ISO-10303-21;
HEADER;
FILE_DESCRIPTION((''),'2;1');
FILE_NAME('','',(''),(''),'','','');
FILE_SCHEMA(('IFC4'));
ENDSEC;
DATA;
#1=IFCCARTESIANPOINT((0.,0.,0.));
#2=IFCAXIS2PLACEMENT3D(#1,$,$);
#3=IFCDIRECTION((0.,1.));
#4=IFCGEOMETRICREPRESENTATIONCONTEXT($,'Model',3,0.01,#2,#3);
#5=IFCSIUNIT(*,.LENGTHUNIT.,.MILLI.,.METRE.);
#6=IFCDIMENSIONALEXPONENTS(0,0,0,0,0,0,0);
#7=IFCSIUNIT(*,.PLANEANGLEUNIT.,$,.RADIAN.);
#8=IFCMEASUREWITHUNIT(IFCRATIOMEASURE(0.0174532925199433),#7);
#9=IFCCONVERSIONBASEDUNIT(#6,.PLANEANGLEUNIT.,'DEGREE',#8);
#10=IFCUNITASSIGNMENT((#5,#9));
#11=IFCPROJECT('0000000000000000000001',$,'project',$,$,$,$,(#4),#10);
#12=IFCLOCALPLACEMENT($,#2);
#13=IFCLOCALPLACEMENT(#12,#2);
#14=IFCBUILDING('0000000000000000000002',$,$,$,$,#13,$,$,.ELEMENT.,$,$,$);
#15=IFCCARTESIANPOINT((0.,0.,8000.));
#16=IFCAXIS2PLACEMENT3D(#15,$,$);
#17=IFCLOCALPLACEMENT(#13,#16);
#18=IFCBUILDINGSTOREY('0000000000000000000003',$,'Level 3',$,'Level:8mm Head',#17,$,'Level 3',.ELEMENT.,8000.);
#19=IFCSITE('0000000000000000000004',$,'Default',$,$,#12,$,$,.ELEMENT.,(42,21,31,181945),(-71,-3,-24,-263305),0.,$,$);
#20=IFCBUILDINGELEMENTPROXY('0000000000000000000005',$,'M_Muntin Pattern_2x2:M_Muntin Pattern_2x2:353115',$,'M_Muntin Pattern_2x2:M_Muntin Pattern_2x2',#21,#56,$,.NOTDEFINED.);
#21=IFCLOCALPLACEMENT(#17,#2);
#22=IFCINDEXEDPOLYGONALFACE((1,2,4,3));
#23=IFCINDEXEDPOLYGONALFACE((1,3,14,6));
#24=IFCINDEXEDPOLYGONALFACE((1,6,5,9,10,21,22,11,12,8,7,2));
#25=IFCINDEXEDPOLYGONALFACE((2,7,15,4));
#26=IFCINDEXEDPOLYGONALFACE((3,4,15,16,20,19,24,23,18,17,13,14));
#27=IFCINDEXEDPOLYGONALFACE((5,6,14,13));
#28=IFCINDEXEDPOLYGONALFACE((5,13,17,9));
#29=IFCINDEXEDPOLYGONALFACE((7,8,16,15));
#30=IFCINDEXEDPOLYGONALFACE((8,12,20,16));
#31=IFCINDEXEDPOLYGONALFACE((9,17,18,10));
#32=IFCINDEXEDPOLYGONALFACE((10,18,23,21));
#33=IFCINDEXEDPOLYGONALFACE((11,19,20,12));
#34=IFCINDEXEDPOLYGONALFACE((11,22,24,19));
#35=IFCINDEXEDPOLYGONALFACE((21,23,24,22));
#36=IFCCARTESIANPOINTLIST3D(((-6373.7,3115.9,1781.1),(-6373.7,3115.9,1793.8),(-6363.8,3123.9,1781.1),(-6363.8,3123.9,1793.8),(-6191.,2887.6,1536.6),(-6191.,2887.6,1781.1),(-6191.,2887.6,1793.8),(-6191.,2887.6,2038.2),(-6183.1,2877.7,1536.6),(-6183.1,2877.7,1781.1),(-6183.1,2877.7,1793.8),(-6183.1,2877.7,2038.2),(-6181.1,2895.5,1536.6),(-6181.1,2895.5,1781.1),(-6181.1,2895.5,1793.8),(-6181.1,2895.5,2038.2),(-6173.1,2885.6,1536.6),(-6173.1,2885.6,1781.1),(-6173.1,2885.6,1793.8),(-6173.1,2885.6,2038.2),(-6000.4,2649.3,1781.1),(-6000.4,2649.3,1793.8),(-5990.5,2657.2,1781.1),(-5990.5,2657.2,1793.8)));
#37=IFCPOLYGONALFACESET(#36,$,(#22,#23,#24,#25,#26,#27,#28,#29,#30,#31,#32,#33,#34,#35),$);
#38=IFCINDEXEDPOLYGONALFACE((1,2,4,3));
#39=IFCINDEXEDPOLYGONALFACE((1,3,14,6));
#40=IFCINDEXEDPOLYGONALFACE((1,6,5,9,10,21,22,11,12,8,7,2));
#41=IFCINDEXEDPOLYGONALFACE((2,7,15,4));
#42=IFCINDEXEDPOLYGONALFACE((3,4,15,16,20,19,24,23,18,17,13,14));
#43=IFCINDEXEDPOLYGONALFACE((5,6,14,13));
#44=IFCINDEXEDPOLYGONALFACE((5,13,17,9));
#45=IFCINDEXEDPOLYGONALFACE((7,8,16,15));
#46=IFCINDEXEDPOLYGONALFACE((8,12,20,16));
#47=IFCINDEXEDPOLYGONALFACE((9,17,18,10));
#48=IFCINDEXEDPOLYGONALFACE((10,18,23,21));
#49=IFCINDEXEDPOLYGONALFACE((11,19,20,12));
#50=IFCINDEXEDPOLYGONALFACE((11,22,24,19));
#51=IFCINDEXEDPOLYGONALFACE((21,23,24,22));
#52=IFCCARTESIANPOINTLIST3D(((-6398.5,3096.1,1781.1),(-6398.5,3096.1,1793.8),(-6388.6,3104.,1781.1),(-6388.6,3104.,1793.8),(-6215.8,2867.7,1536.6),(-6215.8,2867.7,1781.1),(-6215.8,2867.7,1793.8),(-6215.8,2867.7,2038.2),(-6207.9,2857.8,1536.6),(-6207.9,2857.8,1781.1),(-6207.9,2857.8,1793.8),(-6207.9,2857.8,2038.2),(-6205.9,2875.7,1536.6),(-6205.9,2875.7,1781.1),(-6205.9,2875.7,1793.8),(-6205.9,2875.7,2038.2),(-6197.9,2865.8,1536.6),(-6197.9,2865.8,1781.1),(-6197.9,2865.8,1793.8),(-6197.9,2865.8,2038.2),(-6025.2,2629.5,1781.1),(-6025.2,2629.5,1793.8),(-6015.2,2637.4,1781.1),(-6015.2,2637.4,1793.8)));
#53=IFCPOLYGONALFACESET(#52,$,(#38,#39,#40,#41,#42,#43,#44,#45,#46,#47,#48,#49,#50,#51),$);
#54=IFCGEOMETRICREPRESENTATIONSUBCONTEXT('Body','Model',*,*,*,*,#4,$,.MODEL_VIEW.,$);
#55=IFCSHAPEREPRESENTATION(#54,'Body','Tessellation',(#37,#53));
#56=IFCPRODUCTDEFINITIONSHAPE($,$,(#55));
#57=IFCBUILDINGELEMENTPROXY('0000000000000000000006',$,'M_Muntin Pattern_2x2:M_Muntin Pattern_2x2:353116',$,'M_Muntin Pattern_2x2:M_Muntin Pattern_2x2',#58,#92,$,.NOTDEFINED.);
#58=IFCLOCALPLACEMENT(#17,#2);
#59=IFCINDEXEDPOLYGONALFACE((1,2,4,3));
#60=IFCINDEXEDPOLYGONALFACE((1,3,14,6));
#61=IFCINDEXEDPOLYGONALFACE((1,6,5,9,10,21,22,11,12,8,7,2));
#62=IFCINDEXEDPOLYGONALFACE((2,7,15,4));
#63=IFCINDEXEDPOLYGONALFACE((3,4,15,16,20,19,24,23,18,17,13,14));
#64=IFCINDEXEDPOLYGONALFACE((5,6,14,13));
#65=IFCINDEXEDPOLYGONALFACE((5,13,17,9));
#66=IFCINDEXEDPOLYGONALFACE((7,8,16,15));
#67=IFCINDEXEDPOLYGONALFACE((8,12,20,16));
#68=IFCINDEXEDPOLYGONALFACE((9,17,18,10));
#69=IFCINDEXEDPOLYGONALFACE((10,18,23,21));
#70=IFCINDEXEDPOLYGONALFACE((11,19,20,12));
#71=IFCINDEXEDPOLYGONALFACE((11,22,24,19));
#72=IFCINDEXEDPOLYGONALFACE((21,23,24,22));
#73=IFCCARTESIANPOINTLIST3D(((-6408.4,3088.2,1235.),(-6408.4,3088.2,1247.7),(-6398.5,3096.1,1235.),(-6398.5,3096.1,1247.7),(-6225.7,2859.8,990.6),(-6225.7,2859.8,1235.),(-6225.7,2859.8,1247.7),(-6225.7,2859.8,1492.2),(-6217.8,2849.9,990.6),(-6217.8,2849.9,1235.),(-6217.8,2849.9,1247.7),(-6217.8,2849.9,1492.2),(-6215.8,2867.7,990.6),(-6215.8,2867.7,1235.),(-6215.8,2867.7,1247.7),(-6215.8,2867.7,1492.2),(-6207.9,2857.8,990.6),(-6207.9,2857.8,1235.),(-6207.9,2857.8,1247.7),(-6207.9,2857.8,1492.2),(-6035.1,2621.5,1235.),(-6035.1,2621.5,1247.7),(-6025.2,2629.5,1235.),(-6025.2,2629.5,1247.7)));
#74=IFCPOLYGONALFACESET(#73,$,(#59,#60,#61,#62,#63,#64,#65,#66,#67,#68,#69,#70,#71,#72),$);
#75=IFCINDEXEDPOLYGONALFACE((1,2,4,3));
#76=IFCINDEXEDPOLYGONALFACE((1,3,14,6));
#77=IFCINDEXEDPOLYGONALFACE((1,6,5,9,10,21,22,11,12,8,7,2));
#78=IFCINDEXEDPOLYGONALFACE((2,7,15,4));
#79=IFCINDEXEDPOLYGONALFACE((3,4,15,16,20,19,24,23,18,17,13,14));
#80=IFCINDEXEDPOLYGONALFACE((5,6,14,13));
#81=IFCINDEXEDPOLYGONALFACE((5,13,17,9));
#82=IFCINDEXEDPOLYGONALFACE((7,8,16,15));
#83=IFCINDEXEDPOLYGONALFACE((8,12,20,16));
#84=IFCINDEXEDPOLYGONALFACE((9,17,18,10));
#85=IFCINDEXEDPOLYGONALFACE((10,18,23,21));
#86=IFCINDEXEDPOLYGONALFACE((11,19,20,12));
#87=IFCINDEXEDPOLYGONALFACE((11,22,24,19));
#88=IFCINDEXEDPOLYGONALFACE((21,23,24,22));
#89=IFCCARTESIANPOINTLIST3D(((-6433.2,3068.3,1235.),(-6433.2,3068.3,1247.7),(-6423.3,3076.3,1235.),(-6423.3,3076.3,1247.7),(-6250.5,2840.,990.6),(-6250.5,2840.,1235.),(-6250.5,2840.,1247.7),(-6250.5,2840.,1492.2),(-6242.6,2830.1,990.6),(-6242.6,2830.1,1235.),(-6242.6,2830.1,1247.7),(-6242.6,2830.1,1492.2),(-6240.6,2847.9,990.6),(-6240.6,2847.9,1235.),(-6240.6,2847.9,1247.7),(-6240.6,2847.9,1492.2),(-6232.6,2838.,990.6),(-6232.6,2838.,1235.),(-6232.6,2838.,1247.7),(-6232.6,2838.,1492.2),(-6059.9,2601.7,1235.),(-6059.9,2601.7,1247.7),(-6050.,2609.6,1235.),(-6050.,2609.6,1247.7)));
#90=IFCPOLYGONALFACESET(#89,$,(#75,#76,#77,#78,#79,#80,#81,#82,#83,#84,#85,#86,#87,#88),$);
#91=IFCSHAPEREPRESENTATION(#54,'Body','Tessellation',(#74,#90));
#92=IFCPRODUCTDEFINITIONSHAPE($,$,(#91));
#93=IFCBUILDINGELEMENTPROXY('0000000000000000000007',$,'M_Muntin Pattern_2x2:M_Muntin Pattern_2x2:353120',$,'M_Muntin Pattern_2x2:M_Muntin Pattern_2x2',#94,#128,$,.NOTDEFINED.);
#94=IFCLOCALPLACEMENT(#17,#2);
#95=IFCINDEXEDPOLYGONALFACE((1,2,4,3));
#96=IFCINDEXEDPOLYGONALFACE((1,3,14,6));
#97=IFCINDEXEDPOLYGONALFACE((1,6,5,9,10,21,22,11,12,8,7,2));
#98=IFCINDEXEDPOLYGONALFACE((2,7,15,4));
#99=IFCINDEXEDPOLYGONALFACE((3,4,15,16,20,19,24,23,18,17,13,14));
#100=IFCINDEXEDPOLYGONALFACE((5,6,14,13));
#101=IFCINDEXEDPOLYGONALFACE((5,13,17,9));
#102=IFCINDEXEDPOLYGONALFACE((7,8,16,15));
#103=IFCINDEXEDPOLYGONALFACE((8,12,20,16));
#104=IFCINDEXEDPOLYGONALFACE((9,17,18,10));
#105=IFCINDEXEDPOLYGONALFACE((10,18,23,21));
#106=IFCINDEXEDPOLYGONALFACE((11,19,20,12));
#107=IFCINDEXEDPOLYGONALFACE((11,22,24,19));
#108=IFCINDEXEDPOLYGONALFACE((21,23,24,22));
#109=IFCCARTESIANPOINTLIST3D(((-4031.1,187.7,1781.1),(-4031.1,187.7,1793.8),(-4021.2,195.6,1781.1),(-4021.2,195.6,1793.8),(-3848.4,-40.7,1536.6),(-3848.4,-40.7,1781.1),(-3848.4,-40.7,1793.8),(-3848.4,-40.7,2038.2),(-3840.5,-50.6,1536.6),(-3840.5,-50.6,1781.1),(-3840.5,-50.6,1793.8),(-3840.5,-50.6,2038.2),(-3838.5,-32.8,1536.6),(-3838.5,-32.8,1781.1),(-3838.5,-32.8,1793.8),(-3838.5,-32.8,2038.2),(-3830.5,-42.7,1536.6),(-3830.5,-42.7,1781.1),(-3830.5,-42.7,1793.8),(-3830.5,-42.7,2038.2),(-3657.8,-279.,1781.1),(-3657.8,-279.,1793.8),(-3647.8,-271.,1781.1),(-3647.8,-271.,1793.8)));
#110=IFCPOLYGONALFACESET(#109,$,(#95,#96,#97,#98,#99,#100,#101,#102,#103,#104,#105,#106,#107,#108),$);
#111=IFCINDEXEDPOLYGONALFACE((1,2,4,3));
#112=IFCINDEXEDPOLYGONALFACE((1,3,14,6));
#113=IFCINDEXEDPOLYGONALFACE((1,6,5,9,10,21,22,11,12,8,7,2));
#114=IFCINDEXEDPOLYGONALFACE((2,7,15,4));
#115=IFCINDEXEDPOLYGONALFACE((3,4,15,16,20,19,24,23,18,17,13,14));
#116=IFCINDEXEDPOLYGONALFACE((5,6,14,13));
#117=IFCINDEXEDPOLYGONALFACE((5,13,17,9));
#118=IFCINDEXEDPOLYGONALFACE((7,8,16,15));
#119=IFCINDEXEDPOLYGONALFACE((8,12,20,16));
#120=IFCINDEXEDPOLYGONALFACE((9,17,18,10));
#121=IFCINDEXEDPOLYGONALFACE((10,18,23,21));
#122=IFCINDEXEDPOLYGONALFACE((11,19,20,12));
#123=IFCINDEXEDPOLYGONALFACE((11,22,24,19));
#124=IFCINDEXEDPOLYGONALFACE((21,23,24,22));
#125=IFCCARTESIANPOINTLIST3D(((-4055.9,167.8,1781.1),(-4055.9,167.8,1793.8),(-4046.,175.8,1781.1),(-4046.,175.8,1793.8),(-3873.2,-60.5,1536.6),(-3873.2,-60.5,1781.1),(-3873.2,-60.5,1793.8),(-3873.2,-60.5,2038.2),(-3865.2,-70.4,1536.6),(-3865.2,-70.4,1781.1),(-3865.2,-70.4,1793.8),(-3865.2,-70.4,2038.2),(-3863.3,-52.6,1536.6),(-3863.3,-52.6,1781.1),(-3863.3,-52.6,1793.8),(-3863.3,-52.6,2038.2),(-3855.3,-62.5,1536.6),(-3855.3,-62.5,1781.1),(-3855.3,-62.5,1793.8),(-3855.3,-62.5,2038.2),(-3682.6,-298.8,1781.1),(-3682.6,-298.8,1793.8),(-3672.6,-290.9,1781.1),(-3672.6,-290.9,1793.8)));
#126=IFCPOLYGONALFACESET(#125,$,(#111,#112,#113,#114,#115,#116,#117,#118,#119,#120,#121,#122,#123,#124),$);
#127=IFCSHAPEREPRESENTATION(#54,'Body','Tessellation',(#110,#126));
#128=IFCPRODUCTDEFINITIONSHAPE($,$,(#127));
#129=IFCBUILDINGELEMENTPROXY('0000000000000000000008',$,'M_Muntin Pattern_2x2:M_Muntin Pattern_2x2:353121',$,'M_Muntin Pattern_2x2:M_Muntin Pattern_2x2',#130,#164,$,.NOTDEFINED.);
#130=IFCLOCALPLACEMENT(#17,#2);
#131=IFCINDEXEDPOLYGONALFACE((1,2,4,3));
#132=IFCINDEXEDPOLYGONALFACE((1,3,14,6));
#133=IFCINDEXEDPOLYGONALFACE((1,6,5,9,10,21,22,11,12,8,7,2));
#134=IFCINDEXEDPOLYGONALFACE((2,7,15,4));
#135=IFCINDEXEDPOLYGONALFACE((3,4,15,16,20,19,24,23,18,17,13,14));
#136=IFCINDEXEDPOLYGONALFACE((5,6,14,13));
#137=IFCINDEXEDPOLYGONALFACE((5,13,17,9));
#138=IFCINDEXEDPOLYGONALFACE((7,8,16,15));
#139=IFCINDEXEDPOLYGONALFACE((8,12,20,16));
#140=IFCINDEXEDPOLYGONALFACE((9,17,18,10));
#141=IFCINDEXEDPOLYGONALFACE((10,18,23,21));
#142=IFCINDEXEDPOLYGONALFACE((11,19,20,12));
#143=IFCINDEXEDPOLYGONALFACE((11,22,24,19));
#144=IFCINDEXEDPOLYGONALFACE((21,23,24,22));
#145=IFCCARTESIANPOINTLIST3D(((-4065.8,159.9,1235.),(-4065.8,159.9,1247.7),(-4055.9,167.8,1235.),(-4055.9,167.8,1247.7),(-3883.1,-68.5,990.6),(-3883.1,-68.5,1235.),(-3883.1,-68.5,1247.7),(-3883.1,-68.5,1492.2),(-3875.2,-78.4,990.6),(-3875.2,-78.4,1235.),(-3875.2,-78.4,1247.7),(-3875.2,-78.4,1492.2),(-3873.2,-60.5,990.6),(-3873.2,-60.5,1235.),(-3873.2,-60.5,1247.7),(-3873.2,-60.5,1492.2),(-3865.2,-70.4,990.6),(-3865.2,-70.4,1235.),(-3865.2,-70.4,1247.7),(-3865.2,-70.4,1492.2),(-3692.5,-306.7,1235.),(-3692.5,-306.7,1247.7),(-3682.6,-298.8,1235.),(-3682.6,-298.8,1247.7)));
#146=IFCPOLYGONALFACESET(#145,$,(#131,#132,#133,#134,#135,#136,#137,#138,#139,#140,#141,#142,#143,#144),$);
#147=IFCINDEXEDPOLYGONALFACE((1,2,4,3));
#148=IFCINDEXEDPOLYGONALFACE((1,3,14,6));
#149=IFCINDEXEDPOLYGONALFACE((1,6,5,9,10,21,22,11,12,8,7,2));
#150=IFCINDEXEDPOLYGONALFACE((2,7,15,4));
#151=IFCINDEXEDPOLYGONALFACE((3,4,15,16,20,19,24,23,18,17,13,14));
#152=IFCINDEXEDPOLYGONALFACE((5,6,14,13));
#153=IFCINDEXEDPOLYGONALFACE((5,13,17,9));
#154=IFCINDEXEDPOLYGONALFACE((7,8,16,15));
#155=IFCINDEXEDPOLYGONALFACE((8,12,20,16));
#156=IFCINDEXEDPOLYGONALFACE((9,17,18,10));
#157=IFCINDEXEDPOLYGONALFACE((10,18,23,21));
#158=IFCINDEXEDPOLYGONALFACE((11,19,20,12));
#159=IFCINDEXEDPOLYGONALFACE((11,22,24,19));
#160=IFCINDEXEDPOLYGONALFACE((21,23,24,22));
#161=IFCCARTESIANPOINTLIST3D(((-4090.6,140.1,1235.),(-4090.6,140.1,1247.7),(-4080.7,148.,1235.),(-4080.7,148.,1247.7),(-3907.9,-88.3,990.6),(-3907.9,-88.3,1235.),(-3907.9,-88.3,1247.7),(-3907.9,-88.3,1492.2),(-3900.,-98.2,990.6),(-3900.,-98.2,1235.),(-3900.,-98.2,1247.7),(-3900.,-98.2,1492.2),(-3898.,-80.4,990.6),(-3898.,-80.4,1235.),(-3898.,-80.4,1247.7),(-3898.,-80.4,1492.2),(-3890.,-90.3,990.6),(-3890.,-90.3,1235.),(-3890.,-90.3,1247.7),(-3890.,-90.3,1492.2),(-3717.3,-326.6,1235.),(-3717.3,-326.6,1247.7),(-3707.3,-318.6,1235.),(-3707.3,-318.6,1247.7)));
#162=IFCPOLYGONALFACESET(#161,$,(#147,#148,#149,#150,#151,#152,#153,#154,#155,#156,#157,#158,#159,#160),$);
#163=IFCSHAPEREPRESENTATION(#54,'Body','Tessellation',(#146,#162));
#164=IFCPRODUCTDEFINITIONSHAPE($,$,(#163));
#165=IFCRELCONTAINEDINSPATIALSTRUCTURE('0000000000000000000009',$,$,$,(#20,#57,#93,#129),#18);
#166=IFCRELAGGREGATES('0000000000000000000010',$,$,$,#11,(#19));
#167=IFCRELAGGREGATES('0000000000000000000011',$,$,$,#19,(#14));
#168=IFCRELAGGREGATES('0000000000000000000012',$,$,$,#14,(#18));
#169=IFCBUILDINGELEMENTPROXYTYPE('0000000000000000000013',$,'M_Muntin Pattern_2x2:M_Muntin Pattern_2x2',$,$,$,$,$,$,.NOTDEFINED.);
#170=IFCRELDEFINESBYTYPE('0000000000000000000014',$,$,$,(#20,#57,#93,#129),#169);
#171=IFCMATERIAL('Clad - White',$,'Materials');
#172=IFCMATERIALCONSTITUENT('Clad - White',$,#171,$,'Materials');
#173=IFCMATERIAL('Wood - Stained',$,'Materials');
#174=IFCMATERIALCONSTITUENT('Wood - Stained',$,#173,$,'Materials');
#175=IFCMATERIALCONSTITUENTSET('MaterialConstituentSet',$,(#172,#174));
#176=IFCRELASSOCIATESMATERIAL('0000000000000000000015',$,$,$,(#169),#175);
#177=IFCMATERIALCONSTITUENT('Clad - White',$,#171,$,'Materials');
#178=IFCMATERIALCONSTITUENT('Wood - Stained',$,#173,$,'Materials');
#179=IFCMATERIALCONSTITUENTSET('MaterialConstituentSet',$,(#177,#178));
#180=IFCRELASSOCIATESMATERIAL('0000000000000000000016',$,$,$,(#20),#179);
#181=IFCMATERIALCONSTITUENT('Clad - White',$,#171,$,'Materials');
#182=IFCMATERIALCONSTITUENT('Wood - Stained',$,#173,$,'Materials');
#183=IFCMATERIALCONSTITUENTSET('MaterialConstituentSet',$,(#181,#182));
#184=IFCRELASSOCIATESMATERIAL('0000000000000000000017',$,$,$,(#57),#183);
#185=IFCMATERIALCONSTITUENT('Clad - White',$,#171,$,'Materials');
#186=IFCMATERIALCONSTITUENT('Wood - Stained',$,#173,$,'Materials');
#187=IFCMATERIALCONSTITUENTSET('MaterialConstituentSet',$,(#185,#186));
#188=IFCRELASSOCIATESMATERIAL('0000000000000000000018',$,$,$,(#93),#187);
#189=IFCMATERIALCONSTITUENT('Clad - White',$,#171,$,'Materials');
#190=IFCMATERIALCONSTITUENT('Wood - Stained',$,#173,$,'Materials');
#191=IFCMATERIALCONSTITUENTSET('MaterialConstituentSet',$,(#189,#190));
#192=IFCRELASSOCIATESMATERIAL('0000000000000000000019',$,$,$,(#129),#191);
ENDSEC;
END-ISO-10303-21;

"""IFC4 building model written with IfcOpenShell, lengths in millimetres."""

from ifc_helpers import new_model, entity, si_unit, converted_unit, direction, frame, origin, place, context, subcontext, project, spatial, polyline, outline, extrude, source, transform, mapped, material, constituent, constituent_set, type_object, type_shapes, element, save


model = new_model("IFC4")

# Units and contexts
model_context = context("Model", 3, precision=0.01, world=origin(), true_north=direction((0.0, 1.0)))
body_context = subcontext(model_context, "Body", "Model", "MODEL_VIEW")
ifc_project = project(units=[si_unit("LENGTHUNIT", "METRE", prefix="MILLI"), converted_unit("PLANEANGLEUNIT", "DEGREE", entity("IfcRatioMeasure", 0.0174532925199433), si_unit("PLANEANGLEUNIT", "RADIAN"), dimensions=[0, 0, 0, 0, 0, 0, 0])], contexts=[model_context])

# Site, building, storey
site_placement = place(None, origin())
site = spatial("IfcSite", under=ifc_project, at=site_placement, Name="Default", CompositionType="ELEMENT", RefLatitude=(42, 21, 31, 181945), RefLongitude=(-71, -3, -24, -263305), RefElevation=0.0)
building_placement = place(site_placement, origin())
building = spatial("IfcBuilding", under=site, at=building_placement, CompositionType="ELEMENT")
storey_placement = place(building_placement, frame((0.0, 0.0, 8000.0)))
storey = spatial("IfcBuildingStorey", under=building, at=storey_placement, Name="Level 3", ObjectType="Level:8mm Head", LongName="Level 3", CompositionType="ELEMENT", Elevation=8000.0)

# Shared definitions
ifc_material_1 = material(Name="Wood - Stained", Category="Materials")

# Building element proxies
ifc_material_2 = material(Name="Clad - White", Category="Materials")
ifc_constituent_1 = constituent(ifc_material_2, Name="Clad - White", Category="Materials")
ifc_constituent_2 = constituent(ifc_material_1, Name="Wood - Stained", Category="Materials")
ifc_constituent_set_1 = constituent_set(constituents=[ifc_constituent_1, ifc_constituent_2], Name="MaterialConstituentSet")
building_element_proxy_type_1 = type_object("IfcBuildingElementProxyType", Name="M_Muntin Pattern_2x2:M_Muntin Pattern_2x2", PredefinedType="NOTDEFINED", material=ifc_constituent_set_1)
shared_shape_1 = source(origin(), body_context, "Body", "SweptSolid", [
    extrude(outline(polyline([(6.4, -6.4), (250.8, -6.4), (250.8, 6.3), (6.4, 6.3), (6.4, 298.8), (-6.3, 298.8), (-6.3, 6.3), (-250.8, 6.3), (-250.8, -6.4), (-6.3, -6.4), (-6.3, -298.8), (6.4, -298.8), (6.4, -6.4)])), frame((0.0, 9.5, 250.8), z_axis=(0.0, 1.0, 0.0), x_axis=(0.0, 0.0, 1.0)), (0.0, 0.0, 1.0), 12.7),
    extrude(outline(polyline([(6.4, -6.4), (250.8, -6.4), (250.8, 6.3), (6.4, 6.3), (6.4, 298.8), (-6.3, 298.8), (-6.3, 6.3), (-250.8, 6.3), (-250.8, -6.4), (-6.3, -6.4), (-6.3, -298.8), (6.4, -298.8), (6.4, -6.4)])), frame((0.0, -22.2, 250.8), z_axis=(0.0, 1.0, 0.0), x_axis=(0.0, 0.0, 1.0)), (0.0, 0.0, 1.0), 12.7),
])
type_shapes(building_element_proxy_type_1, [shared_shape_1])
ifc_constituent_3 = constituent(ifc_material_2, Name="Clad - White", Category="Materials")
ifc_constituent_4 = constituent(ifc_material_1, Name="Wood - Stained", Category="Materials")
ifc_constituent_set_2 = constituent_set(constituents=[ifc_constituent_3, ifc_constituent_4], Name="MaterialConstituentSet")
proxy_1_placement = place(storey_placement, frame((-6194.5, 2876.7, 1536.6), z_axis=(0.0, 0.0, 1.0), x_axis=(0.624695, -0.780869, 0.0)))
element("IfcBuildingElementProxy", 1, at=proxy_1_placement, inside=storey, type_object=building_element_proxy_type_1, material=ifc_constituent_set_2, Name="M_Muntin Pattern_2x2:M_Muntin Pattern_2x2:353115", ObjectType="M_Muntin Pattern_2x2:M_Muntin Pattern_2x2", PredefinedType="NOTDEFINED", context=body_context, shape_type="MappedRepresentation", body=[
    mapped(shared_shape_1, transform((0.0, 0.0, 0.0), scale=1.0)),
])
ifc_constituent_5 = constituent(ifc_material_2, Name="Clad - White", Category="Materials")
ifc_constituent_6 = constituent(ifc_material_1, Name="Wood - Stained", Category="Materials")
ifc_constituent_set_3 = constituent_set(constituents=[ifc_constituent_5, ifc_constituent_6], Name="MaterialConstituentSet")
proxy_2_placement = place(storey_placement, frame((-6229.2, 2848.9, 990.6), z_axis=(0.0, 0.0, 1.0), x_axis=(0.624695, -0.780869, 0.0)))
element("IfcBuildingElementProxy", 2, at=proxy_2_placement, inside=storey, type_object=building_element_proxy_type_1, material=ifc_constituent_set_3, Name="M_Muntin Pattern_2x2:M_Muntin Pattern_2x2:353116", ObjectType="M_Muntin Pattern_2x2:M_Muntin Pattern_2x2", PredefinedType="NOTDEFINED", context=body_context, shape_type="MappedRepresentation", body=[
    mapped(shared_shape_1, transform((0.0, 0.0, 0.0), scale=1.0)),
])
ifc_constituent_7 = constituent(ifc_material_2, Name="Clad - White", Category="Materials")
ifc_constituent_8 = constituent(ifc_material_1, Name="Wood - Stained", Category="Materials")
ifc_constituent_set_4 = constituent_set(constituents=[ifc_constituent_7, ifc_constituent_8], Name="MaterialConstituentSet")
proxy_3_placement = place(storey_placement, frame((-3851.9, -51.6, 1536.6), z_axis=(0.0, 0.0, 1.0), x_axis=(0.624695, -0.780869, 0.0)))
element("IfcBuildingElementProxy", 3, at=proxy_3_placement, inside=storey, type_object=building_element_proxy_type_1, material=ifc_constituent_set_4, Name="M_Muntin Pattern_2x2:M_Muntin Pattern_2x2:353120", ObjectType="M_Muntin Pattern_2x2:M_Muntin Pattern_2x2", PredefinedType="NOTDEFINED", context=body_context, shape_type="MappedRepresentation", body=[
    mapped(shared_shape_1, transform((0.0, 0.0, 0.0), scale=1.0)),
])
ifc_constituent_9 = constituent(ifc_material_2, Name="Clad - White", Category="Materials")
ifc_constituent_10 = constituent(ifc_material_1, Name="Wood - Stained", Category="Materials")
ifc_constituent_set_5 = constituent_set(constituents=[ifc_constituent_9, ifc_constituent_10], Name="MaterialConstituentSet")
proxy_4_placement = place(storey_placement, frame((-3886.6, -79.4, 990.6), z_axis=(0.0, 0.0, 1.0), x_axis=(0.624695, -0.780869, 0.0)))
element("IfcBuildingElementProxy", 4, at=proxy_4_placement, inside=storey, type_object=building_element_proxy_type_1, material=ifc_constituent_set_5, Name="M_Muntin Pattern_2x2:M_Muntin Pattern_2x2:353121", ObjectType="M_Muntin Pattern_2x2:M_Muntin Pattern_2x2", PredefinedType="NOTDEFINED", context=body_context, shape_type="MappedRepresentation", body=[
    mapped(shared_shape_1, transform((0.0, 0.0, 0.0), scale=1.0)),
])

save(model, "model.ifc")
